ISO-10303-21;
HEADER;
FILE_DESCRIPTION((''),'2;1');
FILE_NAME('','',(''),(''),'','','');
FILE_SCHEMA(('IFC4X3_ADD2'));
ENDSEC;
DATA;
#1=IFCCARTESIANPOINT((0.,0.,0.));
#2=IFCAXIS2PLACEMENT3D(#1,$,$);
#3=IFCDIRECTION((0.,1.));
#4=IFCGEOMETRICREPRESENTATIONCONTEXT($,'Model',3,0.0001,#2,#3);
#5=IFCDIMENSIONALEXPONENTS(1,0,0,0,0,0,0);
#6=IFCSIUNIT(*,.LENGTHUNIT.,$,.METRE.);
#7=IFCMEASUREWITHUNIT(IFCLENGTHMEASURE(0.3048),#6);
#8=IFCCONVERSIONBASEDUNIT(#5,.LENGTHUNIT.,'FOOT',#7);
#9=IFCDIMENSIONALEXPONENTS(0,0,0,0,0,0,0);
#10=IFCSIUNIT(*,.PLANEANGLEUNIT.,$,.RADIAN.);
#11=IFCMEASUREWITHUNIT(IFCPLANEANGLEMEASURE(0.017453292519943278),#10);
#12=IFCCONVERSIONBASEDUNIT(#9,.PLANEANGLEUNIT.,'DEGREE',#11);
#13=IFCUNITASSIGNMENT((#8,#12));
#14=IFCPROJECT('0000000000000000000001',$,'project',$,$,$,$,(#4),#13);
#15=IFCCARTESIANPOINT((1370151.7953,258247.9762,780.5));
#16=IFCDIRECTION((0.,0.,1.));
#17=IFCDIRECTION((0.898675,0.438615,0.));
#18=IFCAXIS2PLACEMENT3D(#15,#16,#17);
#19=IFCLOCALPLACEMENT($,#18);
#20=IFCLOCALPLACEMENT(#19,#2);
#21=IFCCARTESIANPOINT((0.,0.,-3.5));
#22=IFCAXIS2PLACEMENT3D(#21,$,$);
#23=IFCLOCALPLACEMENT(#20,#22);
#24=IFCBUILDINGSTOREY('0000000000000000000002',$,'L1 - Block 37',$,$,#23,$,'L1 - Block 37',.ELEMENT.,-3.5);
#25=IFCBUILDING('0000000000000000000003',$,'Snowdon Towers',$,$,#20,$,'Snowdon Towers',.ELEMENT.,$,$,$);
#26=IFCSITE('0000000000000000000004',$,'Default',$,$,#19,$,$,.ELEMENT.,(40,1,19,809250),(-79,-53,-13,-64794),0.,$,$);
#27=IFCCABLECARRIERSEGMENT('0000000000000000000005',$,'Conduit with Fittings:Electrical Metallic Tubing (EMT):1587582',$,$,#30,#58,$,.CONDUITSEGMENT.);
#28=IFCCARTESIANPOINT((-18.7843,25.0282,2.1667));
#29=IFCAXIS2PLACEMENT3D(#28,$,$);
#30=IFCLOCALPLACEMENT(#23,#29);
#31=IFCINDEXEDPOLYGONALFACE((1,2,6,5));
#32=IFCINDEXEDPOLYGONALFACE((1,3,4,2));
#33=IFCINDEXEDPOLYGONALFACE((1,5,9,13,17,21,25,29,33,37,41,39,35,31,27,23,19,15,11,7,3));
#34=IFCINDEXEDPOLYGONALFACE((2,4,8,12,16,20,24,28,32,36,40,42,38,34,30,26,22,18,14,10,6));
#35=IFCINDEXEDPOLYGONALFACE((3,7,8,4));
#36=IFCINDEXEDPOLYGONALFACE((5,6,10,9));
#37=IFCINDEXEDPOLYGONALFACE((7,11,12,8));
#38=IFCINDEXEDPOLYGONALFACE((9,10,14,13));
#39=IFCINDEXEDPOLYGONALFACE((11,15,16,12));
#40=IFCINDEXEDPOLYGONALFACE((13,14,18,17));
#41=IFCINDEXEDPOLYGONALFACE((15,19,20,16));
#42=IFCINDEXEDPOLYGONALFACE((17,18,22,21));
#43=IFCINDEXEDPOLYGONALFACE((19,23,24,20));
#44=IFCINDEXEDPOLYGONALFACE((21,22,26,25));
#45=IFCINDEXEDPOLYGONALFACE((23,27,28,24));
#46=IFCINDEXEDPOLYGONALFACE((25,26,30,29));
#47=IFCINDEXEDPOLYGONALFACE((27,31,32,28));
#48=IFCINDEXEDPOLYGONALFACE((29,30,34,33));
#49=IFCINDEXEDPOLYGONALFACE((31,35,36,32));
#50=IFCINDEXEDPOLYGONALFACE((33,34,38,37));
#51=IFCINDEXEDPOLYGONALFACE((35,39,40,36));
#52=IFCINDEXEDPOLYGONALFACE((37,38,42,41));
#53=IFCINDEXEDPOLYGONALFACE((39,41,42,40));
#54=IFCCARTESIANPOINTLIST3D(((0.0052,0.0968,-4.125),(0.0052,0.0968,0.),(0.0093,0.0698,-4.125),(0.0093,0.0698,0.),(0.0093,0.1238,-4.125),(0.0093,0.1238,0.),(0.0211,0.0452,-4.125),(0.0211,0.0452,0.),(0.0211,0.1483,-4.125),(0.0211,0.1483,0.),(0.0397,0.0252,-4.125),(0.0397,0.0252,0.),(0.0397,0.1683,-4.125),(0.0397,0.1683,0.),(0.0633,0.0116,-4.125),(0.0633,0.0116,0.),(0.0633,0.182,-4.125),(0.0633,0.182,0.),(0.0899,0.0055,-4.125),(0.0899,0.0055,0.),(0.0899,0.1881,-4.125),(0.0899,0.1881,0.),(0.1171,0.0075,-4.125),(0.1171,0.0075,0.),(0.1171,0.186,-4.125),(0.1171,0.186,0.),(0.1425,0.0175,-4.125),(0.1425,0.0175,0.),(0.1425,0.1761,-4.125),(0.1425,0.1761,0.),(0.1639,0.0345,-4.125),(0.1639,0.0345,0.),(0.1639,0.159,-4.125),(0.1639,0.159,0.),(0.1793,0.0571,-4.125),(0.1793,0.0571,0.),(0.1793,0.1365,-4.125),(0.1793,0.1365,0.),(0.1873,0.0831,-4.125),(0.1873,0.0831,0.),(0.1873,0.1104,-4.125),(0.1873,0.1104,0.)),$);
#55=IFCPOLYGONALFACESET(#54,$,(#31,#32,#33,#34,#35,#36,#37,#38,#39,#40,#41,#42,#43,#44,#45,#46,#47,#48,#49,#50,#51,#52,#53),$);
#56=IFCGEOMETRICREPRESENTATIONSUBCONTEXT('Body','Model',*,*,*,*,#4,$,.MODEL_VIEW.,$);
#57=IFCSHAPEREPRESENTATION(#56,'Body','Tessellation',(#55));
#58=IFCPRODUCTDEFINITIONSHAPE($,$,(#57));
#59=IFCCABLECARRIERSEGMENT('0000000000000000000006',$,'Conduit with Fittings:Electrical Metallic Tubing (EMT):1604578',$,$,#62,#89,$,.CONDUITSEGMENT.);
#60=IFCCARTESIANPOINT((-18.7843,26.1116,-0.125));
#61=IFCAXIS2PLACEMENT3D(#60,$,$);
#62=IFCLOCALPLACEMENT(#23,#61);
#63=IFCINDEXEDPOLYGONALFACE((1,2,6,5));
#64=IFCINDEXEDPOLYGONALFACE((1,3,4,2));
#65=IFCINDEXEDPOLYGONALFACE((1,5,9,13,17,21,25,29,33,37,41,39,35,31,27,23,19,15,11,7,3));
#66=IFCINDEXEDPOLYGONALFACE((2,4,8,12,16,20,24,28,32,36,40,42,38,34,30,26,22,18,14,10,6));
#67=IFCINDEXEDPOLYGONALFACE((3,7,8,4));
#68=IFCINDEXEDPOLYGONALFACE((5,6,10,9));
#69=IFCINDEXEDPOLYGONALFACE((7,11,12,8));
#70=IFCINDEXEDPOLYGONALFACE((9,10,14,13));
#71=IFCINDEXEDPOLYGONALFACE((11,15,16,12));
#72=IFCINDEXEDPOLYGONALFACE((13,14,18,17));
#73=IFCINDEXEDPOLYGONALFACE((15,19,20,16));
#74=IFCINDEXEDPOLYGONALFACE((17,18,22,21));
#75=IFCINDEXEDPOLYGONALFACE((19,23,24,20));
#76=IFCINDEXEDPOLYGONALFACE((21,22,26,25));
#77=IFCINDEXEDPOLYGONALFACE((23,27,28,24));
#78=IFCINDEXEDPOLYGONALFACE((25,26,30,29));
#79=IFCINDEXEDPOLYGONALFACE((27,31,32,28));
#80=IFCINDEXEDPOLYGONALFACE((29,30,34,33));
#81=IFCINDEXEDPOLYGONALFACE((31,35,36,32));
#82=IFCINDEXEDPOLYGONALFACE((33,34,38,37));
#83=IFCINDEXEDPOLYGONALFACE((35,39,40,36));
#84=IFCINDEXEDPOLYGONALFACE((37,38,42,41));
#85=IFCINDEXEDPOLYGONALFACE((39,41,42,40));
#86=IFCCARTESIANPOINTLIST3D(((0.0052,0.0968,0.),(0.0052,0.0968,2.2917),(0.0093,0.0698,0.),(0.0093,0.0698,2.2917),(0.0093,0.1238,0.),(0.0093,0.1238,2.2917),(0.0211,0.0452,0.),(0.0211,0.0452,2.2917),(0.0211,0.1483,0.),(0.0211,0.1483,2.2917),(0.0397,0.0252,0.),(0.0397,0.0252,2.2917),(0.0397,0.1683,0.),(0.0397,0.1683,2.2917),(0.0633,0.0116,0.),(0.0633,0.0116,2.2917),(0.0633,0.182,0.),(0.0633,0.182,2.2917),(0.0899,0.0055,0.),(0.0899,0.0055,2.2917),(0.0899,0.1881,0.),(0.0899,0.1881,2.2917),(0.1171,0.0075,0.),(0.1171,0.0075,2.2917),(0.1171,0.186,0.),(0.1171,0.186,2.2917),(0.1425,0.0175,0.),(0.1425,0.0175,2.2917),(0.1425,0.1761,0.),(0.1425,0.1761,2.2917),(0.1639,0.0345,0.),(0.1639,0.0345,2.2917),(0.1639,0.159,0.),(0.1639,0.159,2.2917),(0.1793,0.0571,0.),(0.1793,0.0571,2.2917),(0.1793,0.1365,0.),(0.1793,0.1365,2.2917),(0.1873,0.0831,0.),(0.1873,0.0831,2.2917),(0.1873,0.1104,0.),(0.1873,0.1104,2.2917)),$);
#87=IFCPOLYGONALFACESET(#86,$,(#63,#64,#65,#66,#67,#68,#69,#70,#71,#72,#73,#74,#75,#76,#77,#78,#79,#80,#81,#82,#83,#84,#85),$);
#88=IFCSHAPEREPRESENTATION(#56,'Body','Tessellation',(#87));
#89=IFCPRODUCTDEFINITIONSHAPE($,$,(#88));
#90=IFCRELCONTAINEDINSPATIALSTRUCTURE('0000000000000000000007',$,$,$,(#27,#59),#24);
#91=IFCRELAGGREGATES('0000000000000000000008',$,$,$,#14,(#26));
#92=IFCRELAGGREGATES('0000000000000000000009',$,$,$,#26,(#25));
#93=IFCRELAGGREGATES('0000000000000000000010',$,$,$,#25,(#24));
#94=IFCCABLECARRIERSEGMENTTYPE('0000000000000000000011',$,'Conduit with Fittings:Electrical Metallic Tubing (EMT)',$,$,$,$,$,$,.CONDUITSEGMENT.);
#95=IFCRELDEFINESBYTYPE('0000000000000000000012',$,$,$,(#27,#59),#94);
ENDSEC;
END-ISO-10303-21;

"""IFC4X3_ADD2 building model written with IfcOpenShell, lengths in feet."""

from ifc_helpers import new_model, entity, si_unit, converted_unit, direction, frame, frame_2d, origin, place, context, subcontext, project, spatial, circle, extrude, type_object, element, save


model = new_model("IFC4X3_ADD2")

# Units and contexts
model_context = context("Model", 3, precision=0.0001, world=origin(), true_north=direction((0.0, 1.0)))
body_context = subcontext(model_context, "Body", "Model", "MODEL_VIEW")
ifc_project = project(units=[converted_unit("LENGTHUNIT", "FOOT", entity("IfcLengthMeasure", 0.3048), si_unit("LENGTHUNIT", "METRE"), dimensions=[1, 0, 0, 0, 0, 0, 0]), converted_unit("PLANEANGLEUNIT", "DEGREE", entity("IfcPlaneAngleMeasure", 0.017453292519943278), si_unit("PLANEANGLEUNIT", "RADIAN"), dimensions=[0, 0, 0, 0, 0, 0, 0])], contexts=[model_context])

# Site, building, storey
site_placement = place(None, frame((1370151.7953, 258247.9762, 780.5), z_axis=(0.0, 0.0, 1.0), x_axis=(0.898675, 0.438615, 0.0)))
site = spatial("IfcSite", under=ifc_project, at=site_placement, Name="Default", CompositionType="ELEMENT", RefLatitude=(40, 1, 19, 809250), RefLongitude=(-79, -53, -13, -64794), RefElevation=0.0)
building_placement = place(site_placement, origin())
building = spatial("IfcBuilding", under=site, at=building_placement, Name="Snowdon Towers", LongName="Snowdon Towers", CompositionType="ELEMENT")
storey_placement = place(building_placement, frame((0.0, 0.0, -3.5)))
storey = spatial("IfcBuildingStorey", under=building, at=storey_placement, Name="L1 - Block 37", LongName="L1 - Block 37", CompositionType="ELEMENT", Elevation=-3.5)

# Cable carrier segments
cable_carrier_segment_type = type_object("IfcCableCarrierSegmentType", Name="Conduit with Fittings:Electrical Metallic Tubing (EMT)", PredefinedType="CONDUITSEGMENT")
cable_carrier_segment_1_placement = place(storey_placement, frame((-18.7843, 25.0282, 2.1667)))
element("IfcCableCarrierSegment", 1, at=cable_carrier_segment_1_placement, inside=storey, type_object=cable_carrier_segment_type, Name="Conduit with Fittings:Electrical Metallic Tubing (EMT):1587582", PredefinedType="CONDUITSEGMENT", context=body_context, shape_type="SweptSolid", body=[
    extrude(circle(Radius=0.0915, at=frame_2d((0.0, 0.0), x_axis=(1.0, 0.0))), frame((0.0968, 0.0968, -4.125), z_axis=(0.0, 0.0, 1.0), x_axis=(-1.0, 0.0, 0.0)), (0.0, 0.0, 1.0), 4.125),
])
cable_carrier_segment_2_placement = place(storey_placement, frame((-18.7843, 26.1116, -0.125)))
element("IfcCableCarrierSegment", 2, at=cable_carrier_segment_2_placement, inside=storey, type_object=cable_carrier_segment_type, Name="Conduit with Fittings:Electrical Metallic Tubing (EMT):1604578", PredefinedType="CONDUITSEGMENT", context=body_context, shape_type="SweptSolid", body=[
    extrude(circle(Radius=0.0915, at=frame_2d((0.0, 0.0), x_axis=(1.0, 0.0))), frame((0.0968, 0.0968, 0.0), z_axis=(0.0, 0.0, 1.0), x_axis=(-1.0, 0.0, 0.0)), (0.0, 0.0, 1.0), 2.2917),
])

save(model, "model.ifc")
